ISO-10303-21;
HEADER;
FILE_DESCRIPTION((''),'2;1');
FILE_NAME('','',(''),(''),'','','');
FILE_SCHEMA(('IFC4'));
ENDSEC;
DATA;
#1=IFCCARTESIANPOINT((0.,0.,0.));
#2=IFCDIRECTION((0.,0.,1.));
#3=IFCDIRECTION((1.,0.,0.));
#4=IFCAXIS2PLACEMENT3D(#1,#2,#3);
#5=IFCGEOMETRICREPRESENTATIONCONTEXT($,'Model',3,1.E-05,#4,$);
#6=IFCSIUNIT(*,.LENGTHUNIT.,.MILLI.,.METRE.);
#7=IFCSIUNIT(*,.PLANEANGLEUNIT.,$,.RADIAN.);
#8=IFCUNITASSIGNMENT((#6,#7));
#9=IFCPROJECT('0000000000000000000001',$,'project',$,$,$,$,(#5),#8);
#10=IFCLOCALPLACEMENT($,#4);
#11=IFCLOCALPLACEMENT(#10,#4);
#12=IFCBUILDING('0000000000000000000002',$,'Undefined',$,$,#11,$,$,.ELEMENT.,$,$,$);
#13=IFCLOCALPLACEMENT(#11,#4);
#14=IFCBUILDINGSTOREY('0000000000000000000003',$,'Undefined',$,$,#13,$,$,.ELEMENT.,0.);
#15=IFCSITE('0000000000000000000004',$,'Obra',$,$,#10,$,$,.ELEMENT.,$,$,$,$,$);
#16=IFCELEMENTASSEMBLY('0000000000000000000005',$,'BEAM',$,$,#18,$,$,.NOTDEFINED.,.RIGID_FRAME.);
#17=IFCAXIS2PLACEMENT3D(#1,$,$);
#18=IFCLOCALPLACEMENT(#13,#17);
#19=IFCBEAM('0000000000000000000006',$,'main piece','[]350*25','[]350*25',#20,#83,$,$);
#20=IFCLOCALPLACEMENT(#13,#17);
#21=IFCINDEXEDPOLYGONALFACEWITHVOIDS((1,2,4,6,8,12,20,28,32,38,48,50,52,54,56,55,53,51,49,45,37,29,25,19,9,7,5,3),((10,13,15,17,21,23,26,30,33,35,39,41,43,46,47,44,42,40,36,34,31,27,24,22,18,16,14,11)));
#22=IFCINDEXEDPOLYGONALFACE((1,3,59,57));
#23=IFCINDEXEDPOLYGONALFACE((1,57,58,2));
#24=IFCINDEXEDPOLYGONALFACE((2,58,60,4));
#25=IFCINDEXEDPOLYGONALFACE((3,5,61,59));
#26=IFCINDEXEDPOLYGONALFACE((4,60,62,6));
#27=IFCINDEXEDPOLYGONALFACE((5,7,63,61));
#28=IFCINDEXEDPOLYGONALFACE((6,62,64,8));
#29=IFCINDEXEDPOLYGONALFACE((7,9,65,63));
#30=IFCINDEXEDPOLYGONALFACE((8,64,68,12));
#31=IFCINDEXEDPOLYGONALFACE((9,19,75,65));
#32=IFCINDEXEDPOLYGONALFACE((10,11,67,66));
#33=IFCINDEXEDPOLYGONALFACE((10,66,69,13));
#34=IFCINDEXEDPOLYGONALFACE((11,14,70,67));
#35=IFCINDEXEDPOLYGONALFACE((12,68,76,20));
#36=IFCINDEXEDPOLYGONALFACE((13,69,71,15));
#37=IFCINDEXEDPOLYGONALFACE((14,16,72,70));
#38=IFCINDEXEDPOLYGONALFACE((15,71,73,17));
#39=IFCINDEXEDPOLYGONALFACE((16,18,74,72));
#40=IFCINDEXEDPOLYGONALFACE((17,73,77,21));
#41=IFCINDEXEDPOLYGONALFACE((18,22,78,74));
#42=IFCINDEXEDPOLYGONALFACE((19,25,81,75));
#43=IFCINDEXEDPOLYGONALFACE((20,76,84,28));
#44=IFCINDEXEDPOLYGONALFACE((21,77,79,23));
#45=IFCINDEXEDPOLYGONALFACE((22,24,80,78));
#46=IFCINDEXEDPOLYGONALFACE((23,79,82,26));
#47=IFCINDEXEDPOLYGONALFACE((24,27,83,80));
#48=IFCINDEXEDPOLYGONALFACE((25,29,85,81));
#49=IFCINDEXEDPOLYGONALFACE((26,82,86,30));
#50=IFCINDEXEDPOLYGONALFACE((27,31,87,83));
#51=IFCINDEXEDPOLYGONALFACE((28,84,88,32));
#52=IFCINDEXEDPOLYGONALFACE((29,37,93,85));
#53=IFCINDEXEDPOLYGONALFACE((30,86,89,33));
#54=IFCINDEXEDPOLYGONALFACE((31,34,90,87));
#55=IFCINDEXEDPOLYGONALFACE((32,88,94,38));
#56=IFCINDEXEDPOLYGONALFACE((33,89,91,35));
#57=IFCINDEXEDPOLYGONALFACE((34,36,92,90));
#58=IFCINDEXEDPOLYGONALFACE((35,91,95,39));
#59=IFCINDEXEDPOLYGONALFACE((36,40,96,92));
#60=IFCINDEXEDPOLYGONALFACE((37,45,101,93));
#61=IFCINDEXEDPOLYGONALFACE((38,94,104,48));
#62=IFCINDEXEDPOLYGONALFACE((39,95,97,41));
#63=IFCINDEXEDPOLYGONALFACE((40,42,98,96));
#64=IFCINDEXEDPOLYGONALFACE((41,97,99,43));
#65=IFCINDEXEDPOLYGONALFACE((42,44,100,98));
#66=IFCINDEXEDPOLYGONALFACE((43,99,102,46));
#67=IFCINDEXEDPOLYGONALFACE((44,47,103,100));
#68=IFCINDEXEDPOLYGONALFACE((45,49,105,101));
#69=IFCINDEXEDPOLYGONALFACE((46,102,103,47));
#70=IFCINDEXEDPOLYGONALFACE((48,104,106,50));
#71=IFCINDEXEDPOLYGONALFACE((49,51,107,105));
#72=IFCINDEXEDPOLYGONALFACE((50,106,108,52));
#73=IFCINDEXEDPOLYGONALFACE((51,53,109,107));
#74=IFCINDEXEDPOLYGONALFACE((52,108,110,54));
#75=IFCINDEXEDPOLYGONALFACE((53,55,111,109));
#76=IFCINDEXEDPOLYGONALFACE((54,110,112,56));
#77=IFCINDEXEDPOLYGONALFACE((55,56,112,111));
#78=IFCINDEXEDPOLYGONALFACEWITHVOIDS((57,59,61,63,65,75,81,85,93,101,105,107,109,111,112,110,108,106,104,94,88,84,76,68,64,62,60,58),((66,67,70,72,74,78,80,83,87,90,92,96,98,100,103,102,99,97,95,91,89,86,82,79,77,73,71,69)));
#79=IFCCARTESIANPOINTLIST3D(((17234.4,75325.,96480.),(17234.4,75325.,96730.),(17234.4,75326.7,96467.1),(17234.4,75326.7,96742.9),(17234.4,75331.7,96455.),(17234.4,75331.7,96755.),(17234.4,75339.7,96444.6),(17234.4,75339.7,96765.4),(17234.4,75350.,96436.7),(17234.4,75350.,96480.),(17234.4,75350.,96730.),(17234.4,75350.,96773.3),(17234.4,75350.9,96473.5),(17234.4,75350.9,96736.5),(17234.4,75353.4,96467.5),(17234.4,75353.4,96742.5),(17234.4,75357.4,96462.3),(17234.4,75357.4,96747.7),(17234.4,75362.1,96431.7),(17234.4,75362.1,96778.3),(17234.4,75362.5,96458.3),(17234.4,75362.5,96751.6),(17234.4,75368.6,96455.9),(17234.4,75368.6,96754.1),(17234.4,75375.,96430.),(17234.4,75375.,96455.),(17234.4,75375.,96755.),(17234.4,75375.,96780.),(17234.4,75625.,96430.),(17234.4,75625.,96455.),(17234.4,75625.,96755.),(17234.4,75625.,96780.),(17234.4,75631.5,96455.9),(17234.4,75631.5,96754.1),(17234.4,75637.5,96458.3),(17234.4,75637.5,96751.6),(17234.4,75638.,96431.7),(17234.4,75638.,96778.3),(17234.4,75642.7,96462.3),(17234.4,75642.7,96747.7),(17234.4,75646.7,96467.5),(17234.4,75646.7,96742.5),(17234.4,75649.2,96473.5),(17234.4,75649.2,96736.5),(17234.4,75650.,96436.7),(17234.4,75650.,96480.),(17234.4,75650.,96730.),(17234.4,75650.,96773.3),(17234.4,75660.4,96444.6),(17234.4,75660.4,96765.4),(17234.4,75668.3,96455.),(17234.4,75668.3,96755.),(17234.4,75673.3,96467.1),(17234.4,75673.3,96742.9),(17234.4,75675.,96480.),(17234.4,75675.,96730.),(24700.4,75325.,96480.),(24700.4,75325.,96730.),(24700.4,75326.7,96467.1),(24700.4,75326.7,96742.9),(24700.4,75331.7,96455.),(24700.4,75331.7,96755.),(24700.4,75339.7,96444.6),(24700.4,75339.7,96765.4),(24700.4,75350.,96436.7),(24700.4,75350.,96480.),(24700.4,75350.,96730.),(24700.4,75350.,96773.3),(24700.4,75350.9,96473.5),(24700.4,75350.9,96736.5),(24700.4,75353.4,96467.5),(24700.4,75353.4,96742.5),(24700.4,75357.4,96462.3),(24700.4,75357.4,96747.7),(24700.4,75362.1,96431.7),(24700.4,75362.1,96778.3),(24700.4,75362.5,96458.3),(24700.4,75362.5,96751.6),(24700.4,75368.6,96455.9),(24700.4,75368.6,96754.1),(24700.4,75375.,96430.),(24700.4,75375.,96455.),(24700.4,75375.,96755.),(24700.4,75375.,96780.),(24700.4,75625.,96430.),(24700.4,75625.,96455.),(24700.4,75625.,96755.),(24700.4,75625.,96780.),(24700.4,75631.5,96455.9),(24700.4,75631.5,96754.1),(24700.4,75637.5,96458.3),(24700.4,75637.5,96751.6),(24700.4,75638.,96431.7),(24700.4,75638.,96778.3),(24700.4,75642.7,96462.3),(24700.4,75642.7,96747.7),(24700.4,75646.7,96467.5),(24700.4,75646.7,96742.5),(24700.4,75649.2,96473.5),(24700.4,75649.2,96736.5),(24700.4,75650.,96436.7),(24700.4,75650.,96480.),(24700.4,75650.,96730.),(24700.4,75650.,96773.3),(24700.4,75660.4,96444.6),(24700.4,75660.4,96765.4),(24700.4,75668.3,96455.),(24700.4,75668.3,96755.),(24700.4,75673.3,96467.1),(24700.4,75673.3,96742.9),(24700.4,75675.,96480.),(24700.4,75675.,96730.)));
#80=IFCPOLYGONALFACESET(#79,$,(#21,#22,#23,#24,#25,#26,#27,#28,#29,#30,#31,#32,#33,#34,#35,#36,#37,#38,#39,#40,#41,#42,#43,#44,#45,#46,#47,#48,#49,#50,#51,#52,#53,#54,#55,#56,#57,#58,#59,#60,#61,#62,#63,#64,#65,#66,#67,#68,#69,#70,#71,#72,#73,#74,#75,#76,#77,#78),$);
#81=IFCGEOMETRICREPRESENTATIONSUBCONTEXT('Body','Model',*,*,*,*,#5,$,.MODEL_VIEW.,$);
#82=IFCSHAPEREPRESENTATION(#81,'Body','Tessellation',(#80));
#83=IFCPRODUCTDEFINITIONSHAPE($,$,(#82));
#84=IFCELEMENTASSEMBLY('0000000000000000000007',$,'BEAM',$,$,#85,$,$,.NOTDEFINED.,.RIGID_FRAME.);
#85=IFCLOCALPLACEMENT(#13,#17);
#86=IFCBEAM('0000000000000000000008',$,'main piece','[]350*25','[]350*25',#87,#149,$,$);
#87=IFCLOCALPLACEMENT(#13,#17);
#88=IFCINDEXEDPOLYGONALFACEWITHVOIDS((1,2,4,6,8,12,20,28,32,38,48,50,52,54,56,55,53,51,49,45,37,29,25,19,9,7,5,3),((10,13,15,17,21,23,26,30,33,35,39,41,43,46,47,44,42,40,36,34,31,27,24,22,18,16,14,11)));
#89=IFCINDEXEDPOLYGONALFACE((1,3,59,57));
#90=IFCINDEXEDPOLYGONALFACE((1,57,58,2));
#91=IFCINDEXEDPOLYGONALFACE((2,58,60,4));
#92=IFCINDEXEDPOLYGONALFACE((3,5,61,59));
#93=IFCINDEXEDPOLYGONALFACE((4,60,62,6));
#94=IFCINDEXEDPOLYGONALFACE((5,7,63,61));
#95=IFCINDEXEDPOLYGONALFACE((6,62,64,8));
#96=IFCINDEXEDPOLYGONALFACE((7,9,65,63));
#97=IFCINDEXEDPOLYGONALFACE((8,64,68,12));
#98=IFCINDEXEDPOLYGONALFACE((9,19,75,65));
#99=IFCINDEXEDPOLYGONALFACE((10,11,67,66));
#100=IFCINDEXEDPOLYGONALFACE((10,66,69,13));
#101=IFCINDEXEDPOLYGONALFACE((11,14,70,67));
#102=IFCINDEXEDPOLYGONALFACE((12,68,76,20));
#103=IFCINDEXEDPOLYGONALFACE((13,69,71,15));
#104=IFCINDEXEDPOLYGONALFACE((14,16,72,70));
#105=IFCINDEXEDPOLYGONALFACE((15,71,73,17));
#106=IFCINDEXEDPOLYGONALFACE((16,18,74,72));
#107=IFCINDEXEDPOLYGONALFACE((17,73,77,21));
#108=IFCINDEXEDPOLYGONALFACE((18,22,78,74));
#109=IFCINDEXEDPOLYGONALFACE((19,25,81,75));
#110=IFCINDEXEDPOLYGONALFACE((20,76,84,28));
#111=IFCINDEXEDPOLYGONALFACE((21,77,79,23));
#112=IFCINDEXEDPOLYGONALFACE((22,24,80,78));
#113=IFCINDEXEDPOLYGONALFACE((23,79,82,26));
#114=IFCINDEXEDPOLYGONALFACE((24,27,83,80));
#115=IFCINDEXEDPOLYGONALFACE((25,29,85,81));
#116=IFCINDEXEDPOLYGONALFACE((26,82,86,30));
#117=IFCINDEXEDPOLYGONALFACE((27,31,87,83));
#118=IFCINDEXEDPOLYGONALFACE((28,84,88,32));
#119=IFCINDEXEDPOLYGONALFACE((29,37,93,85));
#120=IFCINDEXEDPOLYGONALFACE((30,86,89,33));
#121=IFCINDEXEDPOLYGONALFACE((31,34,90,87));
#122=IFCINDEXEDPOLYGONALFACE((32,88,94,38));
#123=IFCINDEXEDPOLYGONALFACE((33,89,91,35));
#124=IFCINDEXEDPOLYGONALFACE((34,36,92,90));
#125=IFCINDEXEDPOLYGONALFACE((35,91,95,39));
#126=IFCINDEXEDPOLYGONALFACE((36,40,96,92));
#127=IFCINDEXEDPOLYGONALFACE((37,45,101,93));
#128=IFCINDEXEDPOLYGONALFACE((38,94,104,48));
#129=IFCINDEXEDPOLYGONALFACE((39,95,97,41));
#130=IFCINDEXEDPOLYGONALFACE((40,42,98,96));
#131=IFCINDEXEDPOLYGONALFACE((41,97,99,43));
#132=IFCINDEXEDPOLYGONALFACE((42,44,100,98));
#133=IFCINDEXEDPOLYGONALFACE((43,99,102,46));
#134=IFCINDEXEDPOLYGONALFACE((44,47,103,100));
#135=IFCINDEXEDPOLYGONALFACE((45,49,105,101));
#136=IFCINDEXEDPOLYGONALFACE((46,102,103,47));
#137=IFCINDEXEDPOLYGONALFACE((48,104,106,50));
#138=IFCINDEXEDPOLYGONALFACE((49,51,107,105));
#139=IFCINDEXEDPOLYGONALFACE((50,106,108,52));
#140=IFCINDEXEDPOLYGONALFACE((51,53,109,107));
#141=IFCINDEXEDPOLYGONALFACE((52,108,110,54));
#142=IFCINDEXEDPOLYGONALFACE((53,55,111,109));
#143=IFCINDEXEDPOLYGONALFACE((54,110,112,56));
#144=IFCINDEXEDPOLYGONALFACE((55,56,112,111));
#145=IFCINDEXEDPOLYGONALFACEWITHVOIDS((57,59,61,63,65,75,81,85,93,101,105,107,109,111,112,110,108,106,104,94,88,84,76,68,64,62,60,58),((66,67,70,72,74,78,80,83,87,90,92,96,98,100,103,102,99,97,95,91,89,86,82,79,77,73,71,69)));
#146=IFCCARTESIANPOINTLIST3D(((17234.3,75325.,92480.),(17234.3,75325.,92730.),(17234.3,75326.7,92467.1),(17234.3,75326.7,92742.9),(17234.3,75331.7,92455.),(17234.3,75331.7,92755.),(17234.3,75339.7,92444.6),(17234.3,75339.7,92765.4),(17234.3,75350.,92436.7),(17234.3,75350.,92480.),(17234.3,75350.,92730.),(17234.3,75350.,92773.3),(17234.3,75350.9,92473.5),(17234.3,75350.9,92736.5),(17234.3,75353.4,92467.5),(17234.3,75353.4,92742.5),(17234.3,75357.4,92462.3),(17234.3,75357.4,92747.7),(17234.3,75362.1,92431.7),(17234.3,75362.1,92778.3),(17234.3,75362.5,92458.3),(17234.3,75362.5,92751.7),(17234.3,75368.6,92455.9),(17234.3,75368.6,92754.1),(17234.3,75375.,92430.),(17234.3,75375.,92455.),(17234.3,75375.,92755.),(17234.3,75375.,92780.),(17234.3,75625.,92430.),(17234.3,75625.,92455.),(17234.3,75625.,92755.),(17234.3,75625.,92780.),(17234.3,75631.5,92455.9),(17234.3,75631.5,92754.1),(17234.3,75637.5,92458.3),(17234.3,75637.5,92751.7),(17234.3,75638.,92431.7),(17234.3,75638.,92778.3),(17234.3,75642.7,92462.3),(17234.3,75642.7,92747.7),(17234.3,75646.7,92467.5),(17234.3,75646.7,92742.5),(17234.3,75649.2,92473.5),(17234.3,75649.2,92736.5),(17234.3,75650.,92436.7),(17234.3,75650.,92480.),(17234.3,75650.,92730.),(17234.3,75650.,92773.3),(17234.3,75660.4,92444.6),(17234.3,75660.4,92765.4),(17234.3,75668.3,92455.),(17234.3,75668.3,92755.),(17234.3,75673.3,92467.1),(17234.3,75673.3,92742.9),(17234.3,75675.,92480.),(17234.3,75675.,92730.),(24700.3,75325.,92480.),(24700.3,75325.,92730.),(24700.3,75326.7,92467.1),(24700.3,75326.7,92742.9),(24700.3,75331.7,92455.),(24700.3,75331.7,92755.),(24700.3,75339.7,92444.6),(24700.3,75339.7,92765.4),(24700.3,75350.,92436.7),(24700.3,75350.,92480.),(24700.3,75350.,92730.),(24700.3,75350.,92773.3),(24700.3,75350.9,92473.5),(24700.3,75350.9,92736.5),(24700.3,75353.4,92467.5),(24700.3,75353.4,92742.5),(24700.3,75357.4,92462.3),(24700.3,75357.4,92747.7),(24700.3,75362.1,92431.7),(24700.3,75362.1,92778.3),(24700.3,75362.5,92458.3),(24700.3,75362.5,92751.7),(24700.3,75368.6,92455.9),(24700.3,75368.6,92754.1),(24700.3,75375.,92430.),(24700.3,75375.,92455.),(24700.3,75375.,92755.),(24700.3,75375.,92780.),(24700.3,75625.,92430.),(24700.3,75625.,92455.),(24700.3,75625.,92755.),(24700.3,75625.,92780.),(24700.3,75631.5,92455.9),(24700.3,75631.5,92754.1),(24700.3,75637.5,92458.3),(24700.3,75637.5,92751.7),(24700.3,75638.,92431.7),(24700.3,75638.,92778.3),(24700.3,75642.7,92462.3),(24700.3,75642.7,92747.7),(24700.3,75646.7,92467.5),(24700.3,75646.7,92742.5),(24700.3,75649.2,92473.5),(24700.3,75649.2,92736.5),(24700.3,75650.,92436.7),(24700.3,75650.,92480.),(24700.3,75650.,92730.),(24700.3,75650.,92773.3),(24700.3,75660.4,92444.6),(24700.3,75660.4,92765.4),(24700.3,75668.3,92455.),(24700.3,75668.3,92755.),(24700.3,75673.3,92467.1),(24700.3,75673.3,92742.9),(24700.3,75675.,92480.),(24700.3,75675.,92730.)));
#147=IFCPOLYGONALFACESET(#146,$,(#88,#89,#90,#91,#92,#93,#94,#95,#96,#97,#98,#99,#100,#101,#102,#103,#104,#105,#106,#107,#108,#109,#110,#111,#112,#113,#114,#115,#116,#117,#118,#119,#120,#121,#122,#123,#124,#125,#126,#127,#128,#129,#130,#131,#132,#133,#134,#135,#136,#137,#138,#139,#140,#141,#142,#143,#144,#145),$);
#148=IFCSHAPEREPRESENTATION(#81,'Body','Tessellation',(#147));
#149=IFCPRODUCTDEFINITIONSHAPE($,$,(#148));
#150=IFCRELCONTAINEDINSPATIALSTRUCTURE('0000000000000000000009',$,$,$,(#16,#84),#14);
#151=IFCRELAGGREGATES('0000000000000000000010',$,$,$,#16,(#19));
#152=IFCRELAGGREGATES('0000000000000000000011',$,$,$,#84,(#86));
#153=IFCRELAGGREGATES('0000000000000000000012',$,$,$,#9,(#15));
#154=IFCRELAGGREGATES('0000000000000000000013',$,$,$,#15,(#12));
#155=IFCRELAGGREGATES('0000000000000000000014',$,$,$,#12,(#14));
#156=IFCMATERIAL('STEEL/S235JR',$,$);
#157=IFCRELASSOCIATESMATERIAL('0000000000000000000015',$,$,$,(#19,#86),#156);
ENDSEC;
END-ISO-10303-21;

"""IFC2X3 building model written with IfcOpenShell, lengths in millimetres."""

from ifc_helpers import new_model, si_unit, frame, origin_with_axes, origin_2d_with_axis, place, context, subcontext, project, spatial, hollow_rectangle, extrude, material, element, aggregate, save


model = new_model("IFC2X3")

# Units and contexts
model_context = context("Model", 3, precision=1e-05, world=origin_with_axes())
body_context = subcontext(model_context, "Body", "Model", "MODEL_VIEW")
ifc_project = project(units=[si_unit("LENGTHUNIT", "METRE", prefix="MILLI"), si_unit("PLANEANGLEUNIT", "RADIAN")], contexts=[model_context])

# Site, building, storey
site_placement = place(None, origin_with_axes())
site = spatial("IfcSite", under=ifc_project, at=site_placement, Name="Obra", CompositionType="ELEMENT")
building_placement = place(site_placement, origin_with_axes())
building = spatial("IfcBuilding", under=site, at=building_placement, Name="Undefined", CompositionType="ELEMENT")
storey_placement = place(building_placement, origin_with_axes())
storey = spatial("IfcBuildingStorey", under=building, at=storey_placement, Name="Undefined", CompositionType="ELEMENT", Elevation=0.0)

# Shared definitions
ifc_material = material(Name="STEEL/S235JR")

# Element assemblies, beams
assembly_1_placement = place(storey_placement, origin_with_axes())
assembly_1 = element("IfcElementAssembly", 1, at=assembly_1_placement, inside=storey, Name="BEAM", AssemblyPlace="NOTDEFINED", PredefinedType="RIGID_FRAME")
beam_1_placement = place(assembly_1_placement, frame((24700.4, 75500.0, 96605.0), z_axis=(0.0, 0.0, 1.0), x_axis=(-1.0, 0.0, 0.0)))
beam_1 = element("IfcBeam", 2, at=beam_1_placement, material=ifc_material, Name="main piece", Description="[]350*25", ObjectType="[]350*25", context=body_context, shape_type="SweptSolid", body=[
    extrude(hollow_rectangle(XDim=350.0, YDim=350.0, WallThickness=25.0, InnerFilletRadius=25.0, OuterFilletRadius=50.0, at=origin_2d_with_axis()), frame((7466.0, 0.0, 0.0), z_axis=(-1.0, 0.0, 0.0), x_axis=(0.0, -1.0, 0.0)), (0.0, 0.0, 1.0), 7466.0),
])
aggregate(assembly_1, [beam_1])
assembly_2_placement = place(storey_placement, origin_with_axes())
assembly_2 = element("IfcElementAssembly", 3, at=assembly_2_placement, inside=storey, Name="BEAM", AssemblyPlace="NOTDEFINED", PredefinedType="RIGID_FRAME")
beam_2_placement = place(assembly_2_placement, frame((24700.3, 75500.0, 92605.0), z_axis=(0.0, 0.0, 1.0), x_axis=(-1.0, 0.0, 0.0)))
beam_2 = element("IfcBeam", 4, at=beam_2_placement, material=ifc_material, Name="main piece", Description="[]350*25", ObjectType="[]350*25", context=body_context, shape_type="SweptSolid", body=[
    extrude(hollow_rectangle(XDim=350.0, YDim=350.0, WallThickness=25.0, InnerFilletRadius=25.0, OuterFilletRadius=50.0, at=origin_2d_with_axis()), frame((7466.0, 0.0, 0.0), z_axis=(-1.0, 0.0, 0.0), x_axis=(0.0, -1.0, 0.0)), (0.0, 0.0, 1.0), 7466.0),
])
aggregate(assembly_2, [beam_2])

save(model, "model.ifc")
